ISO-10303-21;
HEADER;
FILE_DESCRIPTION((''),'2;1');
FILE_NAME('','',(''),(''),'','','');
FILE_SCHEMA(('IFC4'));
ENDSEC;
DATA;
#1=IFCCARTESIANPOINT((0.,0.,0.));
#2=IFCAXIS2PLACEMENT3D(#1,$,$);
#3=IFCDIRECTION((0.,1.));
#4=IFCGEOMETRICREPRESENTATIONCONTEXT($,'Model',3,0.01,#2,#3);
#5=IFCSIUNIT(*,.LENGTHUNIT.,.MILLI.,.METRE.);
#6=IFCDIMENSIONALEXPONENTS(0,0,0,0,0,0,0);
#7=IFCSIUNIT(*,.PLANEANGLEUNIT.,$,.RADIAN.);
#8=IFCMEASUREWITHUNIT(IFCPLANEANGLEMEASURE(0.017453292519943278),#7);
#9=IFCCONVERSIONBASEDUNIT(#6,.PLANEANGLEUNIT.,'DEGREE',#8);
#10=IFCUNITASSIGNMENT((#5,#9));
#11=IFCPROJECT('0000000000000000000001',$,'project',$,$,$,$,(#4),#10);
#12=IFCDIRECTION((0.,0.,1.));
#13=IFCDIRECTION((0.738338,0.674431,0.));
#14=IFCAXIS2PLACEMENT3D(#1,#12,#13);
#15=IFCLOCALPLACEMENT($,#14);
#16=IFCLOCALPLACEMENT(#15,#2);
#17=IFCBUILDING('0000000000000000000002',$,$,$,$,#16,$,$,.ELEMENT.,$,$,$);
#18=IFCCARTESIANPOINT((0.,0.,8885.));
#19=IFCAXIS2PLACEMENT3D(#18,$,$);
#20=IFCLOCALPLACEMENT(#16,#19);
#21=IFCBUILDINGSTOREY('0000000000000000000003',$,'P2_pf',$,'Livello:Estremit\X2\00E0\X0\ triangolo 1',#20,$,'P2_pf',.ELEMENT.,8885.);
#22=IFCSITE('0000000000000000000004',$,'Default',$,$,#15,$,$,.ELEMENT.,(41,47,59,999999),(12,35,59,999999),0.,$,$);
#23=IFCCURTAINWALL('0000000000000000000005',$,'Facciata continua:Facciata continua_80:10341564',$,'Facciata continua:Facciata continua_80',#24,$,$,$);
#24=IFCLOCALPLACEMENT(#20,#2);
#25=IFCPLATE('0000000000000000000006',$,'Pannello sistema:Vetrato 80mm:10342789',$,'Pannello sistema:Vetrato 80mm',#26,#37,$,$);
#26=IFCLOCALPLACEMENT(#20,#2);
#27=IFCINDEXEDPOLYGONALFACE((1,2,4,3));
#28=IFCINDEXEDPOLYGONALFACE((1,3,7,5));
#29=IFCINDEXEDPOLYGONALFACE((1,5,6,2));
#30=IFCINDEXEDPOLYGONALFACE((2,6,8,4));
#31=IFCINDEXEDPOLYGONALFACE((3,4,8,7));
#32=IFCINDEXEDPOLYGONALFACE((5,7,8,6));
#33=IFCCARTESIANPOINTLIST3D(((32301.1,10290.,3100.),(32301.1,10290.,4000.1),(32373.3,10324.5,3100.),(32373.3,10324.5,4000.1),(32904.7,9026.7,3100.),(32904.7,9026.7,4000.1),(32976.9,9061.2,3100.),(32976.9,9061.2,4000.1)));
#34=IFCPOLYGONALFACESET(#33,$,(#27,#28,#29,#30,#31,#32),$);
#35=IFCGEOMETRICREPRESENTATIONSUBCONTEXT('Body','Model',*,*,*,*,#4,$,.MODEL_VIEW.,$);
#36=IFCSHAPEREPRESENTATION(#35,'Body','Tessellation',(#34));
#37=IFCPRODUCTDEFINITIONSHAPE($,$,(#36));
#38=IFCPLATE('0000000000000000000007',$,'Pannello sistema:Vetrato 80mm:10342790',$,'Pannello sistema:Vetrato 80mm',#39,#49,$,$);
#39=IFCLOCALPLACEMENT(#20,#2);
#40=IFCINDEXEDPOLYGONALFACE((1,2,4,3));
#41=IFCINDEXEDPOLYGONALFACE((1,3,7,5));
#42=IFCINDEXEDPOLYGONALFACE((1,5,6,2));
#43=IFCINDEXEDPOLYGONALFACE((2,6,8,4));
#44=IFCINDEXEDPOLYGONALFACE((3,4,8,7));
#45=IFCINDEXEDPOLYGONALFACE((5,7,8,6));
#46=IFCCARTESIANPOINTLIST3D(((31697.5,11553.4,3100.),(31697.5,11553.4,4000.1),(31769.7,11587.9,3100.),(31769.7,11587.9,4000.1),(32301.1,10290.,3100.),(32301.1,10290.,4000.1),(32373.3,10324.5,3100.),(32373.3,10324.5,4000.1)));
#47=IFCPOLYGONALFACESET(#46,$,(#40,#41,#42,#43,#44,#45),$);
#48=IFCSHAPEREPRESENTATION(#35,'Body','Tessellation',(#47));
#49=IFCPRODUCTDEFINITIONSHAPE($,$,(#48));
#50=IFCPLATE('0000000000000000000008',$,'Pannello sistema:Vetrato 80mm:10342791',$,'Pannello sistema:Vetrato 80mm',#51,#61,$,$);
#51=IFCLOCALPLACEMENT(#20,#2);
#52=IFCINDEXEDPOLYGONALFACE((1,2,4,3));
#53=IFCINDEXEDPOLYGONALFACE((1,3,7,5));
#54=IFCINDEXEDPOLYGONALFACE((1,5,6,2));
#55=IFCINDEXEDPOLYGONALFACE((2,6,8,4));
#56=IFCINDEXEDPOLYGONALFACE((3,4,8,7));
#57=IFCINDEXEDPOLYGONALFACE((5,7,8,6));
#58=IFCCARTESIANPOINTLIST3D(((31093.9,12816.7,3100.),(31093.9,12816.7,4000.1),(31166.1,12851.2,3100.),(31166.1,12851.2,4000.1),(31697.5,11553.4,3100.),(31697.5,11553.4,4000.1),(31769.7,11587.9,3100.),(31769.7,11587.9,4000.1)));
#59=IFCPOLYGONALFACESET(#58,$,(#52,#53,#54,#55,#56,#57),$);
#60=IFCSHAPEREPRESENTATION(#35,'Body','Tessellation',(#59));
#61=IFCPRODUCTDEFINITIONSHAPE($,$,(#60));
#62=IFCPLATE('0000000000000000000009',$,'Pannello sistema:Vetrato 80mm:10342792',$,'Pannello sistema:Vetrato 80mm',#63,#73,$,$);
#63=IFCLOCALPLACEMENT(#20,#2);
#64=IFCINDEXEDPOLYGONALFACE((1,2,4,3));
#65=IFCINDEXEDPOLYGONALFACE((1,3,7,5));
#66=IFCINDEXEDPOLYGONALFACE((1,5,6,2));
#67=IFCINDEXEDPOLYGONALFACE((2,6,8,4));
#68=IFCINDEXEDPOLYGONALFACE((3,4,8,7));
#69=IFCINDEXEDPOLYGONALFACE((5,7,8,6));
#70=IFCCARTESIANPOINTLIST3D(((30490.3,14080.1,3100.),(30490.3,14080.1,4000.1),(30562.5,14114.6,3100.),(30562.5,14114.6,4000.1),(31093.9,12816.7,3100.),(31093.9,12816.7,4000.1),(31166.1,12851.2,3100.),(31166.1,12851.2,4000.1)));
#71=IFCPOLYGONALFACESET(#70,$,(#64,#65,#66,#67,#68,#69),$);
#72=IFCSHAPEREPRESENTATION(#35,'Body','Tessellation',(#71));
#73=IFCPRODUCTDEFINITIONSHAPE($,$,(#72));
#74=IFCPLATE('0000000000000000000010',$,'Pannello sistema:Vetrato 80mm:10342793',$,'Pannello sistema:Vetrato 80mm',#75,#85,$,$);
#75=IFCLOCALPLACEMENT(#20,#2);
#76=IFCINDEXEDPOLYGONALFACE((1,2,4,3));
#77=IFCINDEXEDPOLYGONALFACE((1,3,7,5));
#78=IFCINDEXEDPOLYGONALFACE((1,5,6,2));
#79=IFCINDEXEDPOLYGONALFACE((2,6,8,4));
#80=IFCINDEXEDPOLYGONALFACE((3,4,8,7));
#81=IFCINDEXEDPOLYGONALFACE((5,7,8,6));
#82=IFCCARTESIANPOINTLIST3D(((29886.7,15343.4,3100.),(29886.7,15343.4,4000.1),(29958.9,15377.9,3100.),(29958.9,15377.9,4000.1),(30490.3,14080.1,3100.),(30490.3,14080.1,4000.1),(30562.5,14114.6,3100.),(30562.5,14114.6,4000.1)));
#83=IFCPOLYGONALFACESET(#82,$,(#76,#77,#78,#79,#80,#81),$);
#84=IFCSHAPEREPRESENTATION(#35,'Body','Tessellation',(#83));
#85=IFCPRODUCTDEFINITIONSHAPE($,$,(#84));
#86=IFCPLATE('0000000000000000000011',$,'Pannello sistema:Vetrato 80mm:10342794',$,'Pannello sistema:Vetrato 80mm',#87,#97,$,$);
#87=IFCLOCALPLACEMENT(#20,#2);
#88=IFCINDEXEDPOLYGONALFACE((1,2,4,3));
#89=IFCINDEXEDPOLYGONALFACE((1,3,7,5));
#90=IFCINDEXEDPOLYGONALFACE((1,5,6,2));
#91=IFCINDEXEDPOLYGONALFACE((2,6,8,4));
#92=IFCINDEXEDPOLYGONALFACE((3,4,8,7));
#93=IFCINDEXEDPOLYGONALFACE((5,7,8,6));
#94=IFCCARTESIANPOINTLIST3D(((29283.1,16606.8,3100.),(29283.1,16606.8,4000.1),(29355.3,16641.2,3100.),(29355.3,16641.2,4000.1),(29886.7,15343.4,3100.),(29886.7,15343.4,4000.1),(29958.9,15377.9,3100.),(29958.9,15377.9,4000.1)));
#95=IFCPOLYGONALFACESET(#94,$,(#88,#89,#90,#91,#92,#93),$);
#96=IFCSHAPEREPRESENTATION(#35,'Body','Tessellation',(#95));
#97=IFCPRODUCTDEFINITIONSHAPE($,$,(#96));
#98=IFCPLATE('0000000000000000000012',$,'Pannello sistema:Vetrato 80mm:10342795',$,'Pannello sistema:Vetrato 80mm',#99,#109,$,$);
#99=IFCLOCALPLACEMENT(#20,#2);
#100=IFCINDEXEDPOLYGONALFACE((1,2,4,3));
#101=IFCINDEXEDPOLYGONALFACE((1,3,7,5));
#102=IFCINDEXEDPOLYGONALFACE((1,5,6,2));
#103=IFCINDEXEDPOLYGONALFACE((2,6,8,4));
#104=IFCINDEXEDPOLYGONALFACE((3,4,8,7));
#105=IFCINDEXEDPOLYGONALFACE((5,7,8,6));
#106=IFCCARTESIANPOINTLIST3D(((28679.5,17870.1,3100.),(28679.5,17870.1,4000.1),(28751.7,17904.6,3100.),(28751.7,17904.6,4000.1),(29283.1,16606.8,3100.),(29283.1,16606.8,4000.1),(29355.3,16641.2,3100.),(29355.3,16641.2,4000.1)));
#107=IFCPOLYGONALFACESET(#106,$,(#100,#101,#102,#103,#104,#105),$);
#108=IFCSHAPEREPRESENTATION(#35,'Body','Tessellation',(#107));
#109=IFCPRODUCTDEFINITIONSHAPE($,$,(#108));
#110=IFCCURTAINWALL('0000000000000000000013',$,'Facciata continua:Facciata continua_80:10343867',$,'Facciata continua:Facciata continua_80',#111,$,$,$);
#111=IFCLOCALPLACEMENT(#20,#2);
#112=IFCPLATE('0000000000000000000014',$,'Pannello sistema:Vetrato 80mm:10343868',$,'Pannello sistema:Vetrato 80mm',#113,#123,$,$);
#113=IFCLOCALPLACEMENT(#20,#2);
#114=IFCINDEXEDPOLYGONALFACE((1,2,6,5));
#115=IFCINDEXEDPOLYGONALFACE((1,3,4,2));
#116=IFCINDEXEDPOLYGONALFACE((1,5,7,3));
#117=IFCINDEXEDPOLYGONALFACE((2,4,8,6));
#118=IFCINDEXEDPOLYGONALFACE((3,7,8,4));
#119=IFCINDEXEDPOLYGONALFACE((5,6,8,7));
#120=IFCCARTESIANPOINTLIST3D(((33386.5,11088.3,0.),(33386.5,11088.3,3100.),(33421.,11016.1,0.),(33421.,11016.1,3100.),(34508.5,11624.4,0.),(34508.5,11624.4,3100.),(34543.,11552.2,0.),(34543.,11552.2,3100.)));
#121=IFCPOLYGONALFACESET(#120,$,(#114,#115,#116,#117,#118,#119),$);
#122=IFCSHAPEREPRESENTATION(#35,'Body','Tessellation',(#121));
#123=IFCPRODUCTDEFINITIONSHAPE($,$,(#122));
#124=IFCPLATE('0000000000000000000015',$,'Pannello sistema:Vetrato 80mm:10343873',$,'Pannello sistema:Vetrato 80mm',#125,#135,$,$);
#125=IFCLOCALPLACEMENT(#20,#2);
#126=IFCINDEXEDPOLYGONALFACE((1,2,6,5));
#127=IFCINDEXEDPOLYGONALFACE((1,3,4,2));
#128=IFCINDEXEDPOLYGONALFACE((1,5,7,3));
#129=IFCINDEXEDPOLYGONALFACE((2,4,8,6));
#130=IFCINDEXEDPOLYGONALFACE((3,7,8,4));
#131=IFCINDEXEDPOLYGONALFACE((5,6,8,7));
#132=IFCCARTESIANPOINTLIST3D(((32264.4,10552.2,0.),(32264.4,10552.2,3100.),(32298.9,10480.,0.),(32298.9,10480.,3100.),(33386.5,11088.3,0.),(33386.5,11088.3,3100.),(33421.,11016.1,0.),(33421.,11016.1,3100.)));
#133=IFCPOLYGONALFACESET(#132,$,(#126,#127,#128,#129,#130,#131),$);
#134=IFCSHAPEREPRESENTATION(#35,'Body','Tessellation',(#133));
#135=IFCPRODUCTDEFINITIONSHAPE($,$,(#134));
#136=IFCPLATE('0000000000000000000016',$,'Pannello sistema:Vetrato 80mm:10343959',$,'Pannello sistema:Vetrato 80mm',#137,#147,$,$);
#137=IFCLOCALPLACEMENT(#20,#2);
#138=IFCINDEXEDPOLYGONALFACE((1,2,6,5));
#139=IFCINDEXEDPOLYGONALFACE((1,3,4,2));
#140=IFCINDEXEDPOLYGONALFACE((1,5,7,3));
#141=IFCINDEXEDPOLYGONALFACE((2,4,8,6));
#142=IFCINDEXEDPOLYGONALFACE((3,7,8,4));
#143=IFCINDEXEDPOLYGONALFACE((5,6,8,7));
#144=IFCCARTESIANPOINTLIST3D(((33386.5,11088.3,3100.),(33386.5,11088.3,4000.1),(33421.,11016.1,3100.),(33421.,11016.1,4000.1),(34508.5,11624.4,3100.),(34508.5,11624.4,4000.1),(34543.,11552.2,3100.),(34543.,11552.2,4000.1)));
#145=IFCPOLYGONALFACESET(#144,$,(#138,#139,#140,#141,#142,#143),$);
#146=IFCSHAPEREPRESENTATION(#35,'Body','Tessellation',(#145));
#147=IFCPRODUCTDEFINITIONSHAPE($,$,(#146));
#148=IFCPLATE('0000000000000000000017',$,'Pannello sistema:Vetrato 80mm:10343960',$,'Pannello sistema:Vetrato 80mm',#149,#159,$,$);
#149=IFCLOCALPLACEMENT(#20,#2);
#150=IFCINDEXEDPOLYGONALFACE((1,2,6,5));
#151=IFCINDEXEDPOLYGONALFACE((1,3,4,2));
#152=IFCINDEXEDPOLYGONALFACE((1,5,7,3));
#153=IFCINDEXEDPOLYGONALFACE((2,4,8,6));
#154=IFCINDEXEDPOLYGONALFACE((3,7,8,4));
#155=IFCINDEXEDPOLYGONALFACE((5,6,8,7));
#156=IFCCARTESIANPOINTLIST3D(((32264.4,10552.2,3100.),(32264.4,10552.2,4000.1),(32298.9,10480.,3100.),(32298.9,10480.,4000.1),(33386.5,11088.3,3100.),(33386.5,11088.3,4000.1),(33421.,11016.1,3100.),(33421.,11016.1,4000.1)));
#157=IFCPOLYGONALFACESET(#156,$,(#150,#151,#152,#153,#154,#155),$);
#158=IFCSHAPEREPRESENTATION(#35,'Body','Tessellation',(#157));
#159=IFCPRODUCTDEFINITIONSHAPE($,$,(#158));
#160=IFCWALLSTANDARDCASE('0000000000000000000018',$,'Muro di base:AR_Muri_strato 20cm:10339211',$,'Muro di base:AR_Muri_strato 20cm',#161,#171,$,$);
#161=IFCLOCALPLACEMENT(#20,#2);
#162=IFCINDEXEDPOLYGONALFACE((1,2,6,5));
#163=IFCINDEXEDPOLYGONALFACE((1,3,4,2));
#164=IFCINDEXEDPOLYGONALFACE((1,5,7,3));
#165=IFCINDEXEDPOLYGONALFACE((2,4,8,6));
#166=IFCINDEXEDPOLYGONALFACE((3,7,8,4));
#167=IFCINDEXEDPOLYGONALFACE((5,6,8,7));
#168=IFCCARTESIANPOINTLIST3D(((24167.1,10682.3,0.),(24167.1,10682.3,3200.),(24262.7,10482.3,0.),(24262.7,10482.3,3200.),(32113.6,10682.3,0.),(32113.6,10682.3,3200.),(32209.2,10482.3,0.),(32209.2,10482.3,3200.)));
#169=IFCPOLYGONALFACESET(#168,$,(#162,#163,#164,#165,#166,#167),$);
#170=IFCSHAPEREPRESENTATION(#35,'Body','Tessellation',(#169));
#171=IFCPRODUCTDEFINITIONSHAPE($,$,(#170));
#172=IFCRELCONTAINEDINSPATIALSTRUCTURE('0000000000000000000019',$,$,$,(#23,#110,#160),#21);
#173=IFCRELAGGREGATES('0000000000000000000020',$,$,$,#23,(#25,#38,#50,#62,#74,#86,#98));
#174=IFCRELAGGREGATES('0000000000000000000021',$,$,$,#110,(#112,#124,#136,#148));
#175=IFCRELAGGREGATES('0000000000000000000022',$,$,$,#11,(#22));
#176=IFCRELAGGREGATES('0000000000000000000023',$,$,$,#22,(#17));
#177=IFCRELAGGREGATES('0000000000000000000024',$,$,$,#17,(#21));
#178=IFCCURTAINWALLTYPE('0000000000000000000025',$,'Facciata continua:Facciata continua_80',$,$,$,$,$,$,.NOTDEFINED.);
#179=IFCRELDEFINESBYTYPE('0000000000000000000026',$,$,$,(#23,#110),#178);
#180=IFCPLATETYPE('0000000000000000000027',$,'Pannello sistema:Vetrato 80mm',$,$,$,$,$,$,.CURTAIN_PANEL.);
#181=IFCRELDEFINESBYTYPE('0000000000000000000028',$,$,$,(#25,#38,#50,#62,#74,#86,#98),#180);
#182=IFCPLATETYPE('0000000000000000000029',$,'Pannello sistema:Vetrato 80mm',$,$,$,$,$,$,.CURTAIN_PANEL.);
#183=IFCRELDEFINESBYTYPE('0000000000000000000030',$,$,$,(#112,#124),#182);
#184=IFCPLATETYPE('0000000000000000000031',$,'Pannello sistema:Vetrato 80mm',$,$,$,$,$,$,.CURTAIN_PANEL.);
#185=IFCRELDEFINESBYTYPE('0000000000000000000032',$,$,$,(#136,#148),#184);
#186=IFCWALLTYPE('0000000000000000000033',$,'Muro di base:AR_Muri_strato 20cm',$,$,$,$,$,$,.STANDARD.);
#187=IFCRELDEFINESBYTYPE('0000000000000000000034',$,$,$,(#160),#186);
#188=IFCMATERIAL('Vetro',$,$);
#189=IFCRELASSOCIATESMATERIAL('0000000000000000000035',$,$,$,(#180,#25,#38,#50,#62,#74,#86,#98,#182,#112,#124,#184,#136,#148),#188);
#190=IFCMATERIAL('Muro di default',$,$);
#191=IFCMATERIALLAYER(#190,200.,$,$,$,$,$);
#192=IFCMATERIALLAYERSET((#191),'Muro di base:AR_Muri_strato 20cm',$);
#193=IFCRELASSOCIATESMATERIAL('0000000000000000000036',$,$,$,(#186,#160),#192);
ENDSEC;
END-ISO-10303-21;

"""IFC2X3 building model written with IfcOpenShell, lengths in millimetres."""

from ifc_helpers import new_model, entity, si_unit, converted_unit, direction, frame, frame_2d, origin, place, context, subcontext, project, spatial, polyline, rectangle, outline, extrude, source, transform, mapped, material, layer, layer_set, layer_usage, type_object, type_shapes, element, aggregate, save


model = new_model("IFC2X3")

# Units and contexts
model_context = context("Model", 3, precision=0.01, world=origin(), true_north=direction((0.0, 1.0)))
body_context = subcontext(model_context, "Body", "Model", "MODEL_VIEW")
ifc_project = project(units=[si_unit("LENGTHUNIT", "METRE", prefix="MILLI"), converted_unit("PLANEANGLEUNIT", "DEGREE", entity("IfcPlaneAngleMeasure", 0.017453292519943278), si_unit("PLANEANGLEUNIT", "RADIAN"), dimensions=[0, 0, 0, 0, 0, 0, 0])], contexts=[model_context])

# Site, building, storey
site_placement = place(None, frame((0.0, 0.0, 0.0), z_axis=(0.0, 0.0, 1.0), x_axis=(0.738338, 0.674431, 0.0)))
site = spatial("IfcSite", under=ifc_project, at=site_placement, Name="Default", CompositionType="ELEMENT", RefLatitude=(41, 47, 59, 999999), RefLongitude=(12, 35, 59, 999999), RefElevation=0.0)
building_placement = place(site_placement, origin())
building = spatial("IfcBuilding", under=site, at=building_placement, CompositionType="ELEMENT")
storey_placement = place(building_placement, frame((0.0, 0.0, 8885.0)))
storey = spatial("IfcBuildingStorey", under=building, at=storey_placement, Name="P2_pf", ObjectType="Livello:Estremità triangolo 1", LongName="P2_pf", CompositionType="ELEMENT", Elevation=8885.0)

# Curtain walls, plates
curtain_wall_type = type_object("IfcCurtainWallType", Name="Facciata continua:Facciata continua_80", PredefinedType="NOTDEFINED")
ifc_material_1 = material(Name="Vetro")
curtain_wall_1_placement = place(storey_placement, frame((0.0, 0.0, -8885.0)))
curtain_wall_1 = element("IfcCurtainWall", 1, at=curtain_wall_1_placement, inside=storey, type_object=curtain_wall_type, Name="Facciata continua:Facciata continua_80:10341564", ObjectType="Facciata continua:Facciata continua_80")
plate_type_1 = type_object("IfcPlateType", Name="Pannello sistema:Vetrato 80mm", PredefinedType="CURTAIN_PANEL", material=ifc_material_1)
shared_shape_1 = source(origin(), body_context, "Body", "SweptSolid", [
    extrude(rectangle(XDim=80.0, YDim=1400.1, at=frame_2d((0.0, 0.0), x_axis=(1.0, 0.0))), frame((0.0, -40.0, 0.0), z_axis=(0.0, 0.0, 1.0), x_axis=(0.0, 1.0, 0.0)), (0.0, 0.0, 1.0), 900.1),
])
type_shapes(plate_type_1, [shared_shape_1])
plate_1_placement = place(curtain_wall_1_placement, frame((32602.9, 9658.4, 11985.0), z_axis=(0.0, 0.0, 1.0), x_axis=(-0.431105, 0.902302, 0.0)))
plate_1 = element("IfcPlate", 2, at=plate_1_placement, type_object=plate_type_1, material=ifc_material_1, Name="Pannello sistema:Vetrato 80mm:10342789", ObjectType="Pannello sistema:Vetrato 80mm", context=body_context, shape_type="MappedRepresentation", body=[
    mapped(shared_shape_1, transform((0.0, 0.0, 0.0), scale=1.0)),
])
plate_2_placement = place(curtain_wall_1_placement, frame((31999.3, 10921.7, 11985.0), z_axis=(0.0, 0.0, 1.0), x_axis=(-0.431105, 0.902302, 0.0)))
plate_2 = element("IfcPlate", 3, at=plate_2_placement, type_object=plate_type_1, material=ifc_material_1, Name="Pannello sistema:Vetrato 80mm:10342790", ObjectType="Pannello sistema:Vetrato 80mm", context=body_context, shape_type="MappedRepresentation", body=[
    mapped(shared_shape_1, transform((0.0, 0.0, 0.0), scale=1.0)),
])
plate_3_placement = place(curtain_wall_1_placement, frame((31395.7, 12185.0, 11985.0), z_axis=(0.0, 0.0, 1.0), x_axis=(-0.431105, 0.902302, 0.0)))
plate_3 = element("IfcPlate", 4, at=plate_3_placement, type_object=plate_type_1, material=ifc_material_1, Name="Pannello sistema:Vetrato 80mm:10342791", ObjectType="Pannello sistema:Vetrato 80mm", context=body_context, shape_type="MappedRepresentation", body=[
    mapped(shared_shape_1, transform((0.0, 0.0, 0.0), scale=1.0)),
])
plate_4_placement = place(curtain_wall_1_placement, frame((30792.1, 13448.4, 11985.0), z_axis=(0.0, 0.0, 1.0), x_axis=(-0.431105, 0.902302, 0.0)))
plate_4 = element("IfcPlate", 5, at=plate_4_placement, type_object=plate_type_1, material=ifc_material_1, Name="Pannello sistema:Vetrato 80mm:10342792", ObjectType="Pannello sistema:Vetrato 80mm", context=body_context, shape_type="MappedRepresentation", body=[
    mapped(shared_shape_1, transform((0.0, 0.0, 0.0), scale=1.0)),
])
plate_5_placement = place(curtain_wall_1_placement, frame((30188.5, 14711.7, 11985.0), z_axis=(0.0, 0.0, 1.0), x_axis=(-0.431105, 0.902302, 0.0)))
plate_5 = element("IfcPlate", 6, at=plate_5_placement, type_object=plate_type_1, material=ifc_material_1, Name="Pannello sistema:Vetrato 80mm:10342793", ObjectType="Pannello sistema:Vetrato 80mm", context=body_context, shape_type="MappedRepresentation", body=[
    mapped(shared_shape_1, transform((0.0, 0.0, 0.0), scale=1.0)),
])
plate_6_placement = place(curtain_wall_1_placement, frame((29584.9, 15975.1, 11985.0), z_axis=(0.0, 0.0, 1.0), x_axis=(-0.431105, 0.902302, 0.0)))
plate_6 = element("IfcPlate", 7, at=plate_6_placement, type_object=plate_type_1, material=ifc_material_1, Name="Pannello sistema:Vetrato 80mm:10342794", ObjectType="Pannello sistema:Vetrato 80mm", context=body_context, shape_type="MappedRepresentation", body=[
    mapped(shared_shape_1, transform((0.0, 0.0, 0.0), scale=1.0)),
])
plate_7_placement = place(curtain_wall_1_placement, frame((28981.3, 17238.4, 11985.0), z_axis=(0.0, 0.0, 1.0), x_axis=(-0.431105, 0.902302, 0.0)))
plate_7 = element("IfcPlate", 8, at=plate_7_placement, type_object=plate_type_1, material=ifc_material_1, Name="Pannello sistema:Vetrato 80mm:10342795", ObjectType="Pannello sistema:Vetrato 80mm", context=body_context, shape_type="MappedRepresentation", body=[
    mapped(shared_shape_1, transform((0.0, 0.0, 0.0), scale=1.0)),
])
aggregate(curtain_wall_1, [plate_1, plate_2, plate_3, plate_4, plate_5, plate_6, plate_7])
curtain_wall_2_placement = place(storey_placement, frame((0.0, 0.0, -8885.0)))
curtain_wall_2 = element("IfcCurtainWall", 9, at=curtain_wall_2_placement, inside=storey, type_object=curtain_wall_type, Name="Facciata continua:Facciata continua_80:10343867", ObjectType="Facciata continua:Facciata continua_80")
plate_type_2 = type_object("IfcPlateType", Name="Pannello sistema:Vetrato 80mm", PredefinedType="CURTAIN_PANEL", material=ifc_material_1)
shared_shape_2 = source(origin(), body_context, "Body", "SweptSolid", [
    extrude(rectangle(XDim=80.0, YDim=1243.5, at=frame_2d((0.0, 0.0), x_axis=(1.0, 0.0))), frame((0.0, -40.0, 0.0), z_axis=(0.0, 0.0, 1.0), x_axis=(0.0, 1.0, 0.0)), (0.0, 0.0, 1.0), 3100.0),
])
type_shapes(plate_type_2, [shared_shape_2])
plate_8_placement = place(curtain_wall_2_placement, frame((33982.0, 11284.1, 8885.0), z_axis=(0.0, 0.0, 1.0), x_axis=(-0.902302, -0.431105, 0.0)))
plate_8 = element("IfcPlate", 10, at=plate_8_placement, type_object=plate_type_2, material=ifc_material_1, Name="Pannello sistema:Vetrato 80mm:10343868", ObjectType="Pannello sistema:Vetrato 80mm", context=body_context, shape_type="MappedRepresentation", body=[
    mapped(shared_shape_2, transform((0.0, 0.0, 0.0), scale=1.0)),
])
plate_9_placement = place(curtain_wall_2_placement, frame((32860.0, 10748.0, 8885.0), z_axis=(0.0, 0.0, 1.0), x_axis=(-0.902302, -0.431105, 0.0)))
plate_9 = element("IfcPlate", 11, at=plate_9_placement, type_object=plate_type_2, material=ifc_material_1, Name="Pannello sistema:Vetrato 80mm:10343873", ObjectType="Pannello sistema:Vetrato 80mm", context=body_context, shape_type="MappedRepresentation", body=[
    mapped(shared_shape_2, transform((0.0, 0.0, 0.0), scale=1.0)),
])
plate_type_3 = type_object("IfcPlateType", Name="Pannello sistema:Vetrato 80mm", PredefinedType="CURTAIN_PANEL", material=ifc_material_1)
shared_shape_3 = source(origin(), body_context, "Body", "SweptSolid", [
    extrude(rectangle(XDim=80.0, YDim=1243.5, at=frame_2d((0.0, 0.0), x_axis=(1.0, 0.0))), frame((0.0, -40.0, 0.0), z_axis=(0.0, 0.0, 1.0), x_axis=(0.0, 1.0, 0.0)), (0.0, 0.0, 1.0), 900.1),
])
type_shapes(plate_type_3, [shared_shape_3])
plate_10_placement = place(curtain_wall_2_placement, frame((33982.0, 11284.1, 11985.0), z_axis=(0.0, 0.0, 1.0), x_axis=(-0.902302, -0.431105, 0.0)))
plate_10 = element("IfcPlate", 12, at=plate_10_placement, type_object=plate_type_3, material=ifc_material_1, Name="Pannello sistema:Vetrato 80mm:10343959", ObjectType="Pannello sistema:Vetrato 80mm", context=body_context, shape_type="MappedRepresentation", body=[
    mapped(shared_shape_3, transform((0.0, 0.0, 0.0), scale=1.0)),
])
plate_11_placement = place(curtain_wall_2_placement, frame((32860.0, 10748.0, 11985.0), z_axis=(0.0, 0.0, 1.0), x_axis=(-0.902302, -0.431105, 0.0)))
plate_11 = element("IfcPlate", 13, at=plate_11_placement, type_object=plate_type_3, material=ifc_material_1, Name="Pannello sistema:Vetrato 80mm:10343960", ObjectType="Pannello sistema:Vetrato 80mm", context=body_context, shape_type="MappedRepresentation", body=[
    mapped(shared_shape_3, transform((0.0, 0.0, 0.0), scale=1.0)),
])
aggregate(curtain_wall_2, [plate_8, plate_9, plate_10, plate_11])

# Wall
ifc_material_2 = material(Name="Muro di default")
ifc_layer = layer(ifc_material_2, 200.0)
ifc_layer_set = layer_set([ifc_layer], Name="Muro di base:AR_Muri_strato 20cm")
ifc_layer_usage = layer_usage(ifc_layer_set, "AXIS2", "NEGATIVE", 100.0)
wall_type = type_object("IfcWallType", Name="Muro di base:AR_Muri_strato 20cm", PredefinedType="STANDARD", material=ifc_layer_set)
wall_placement = place(storey_placement, frame((32209.2, 10582.3, 0.0), z_axis=(0.0, 0.0, 1.0), x_axis=(-1.0, 0.0, 0.0)))
element("IfcWallStandardCase", 14, at=wall_placement, inside=storey, type_object=wall_type, material=ifc_layer_usage, Name="Muro di base:AR_Muri_strato 20cm:10339211", ObjectType="Muro di base:AR_Muri_strato 20cm", context=body_context, shape_type="SweptSolid", body=[
    extrude(outline(polyline([(8042.0, -100.0), (7946.5, 100.0), (0.0, 100.0), (95.6, -100.0), (8042.0, -100.0)])), origin(), (0.0, 0.0, 1.0), 3200.0),
])

save(model, "model.ifc")
